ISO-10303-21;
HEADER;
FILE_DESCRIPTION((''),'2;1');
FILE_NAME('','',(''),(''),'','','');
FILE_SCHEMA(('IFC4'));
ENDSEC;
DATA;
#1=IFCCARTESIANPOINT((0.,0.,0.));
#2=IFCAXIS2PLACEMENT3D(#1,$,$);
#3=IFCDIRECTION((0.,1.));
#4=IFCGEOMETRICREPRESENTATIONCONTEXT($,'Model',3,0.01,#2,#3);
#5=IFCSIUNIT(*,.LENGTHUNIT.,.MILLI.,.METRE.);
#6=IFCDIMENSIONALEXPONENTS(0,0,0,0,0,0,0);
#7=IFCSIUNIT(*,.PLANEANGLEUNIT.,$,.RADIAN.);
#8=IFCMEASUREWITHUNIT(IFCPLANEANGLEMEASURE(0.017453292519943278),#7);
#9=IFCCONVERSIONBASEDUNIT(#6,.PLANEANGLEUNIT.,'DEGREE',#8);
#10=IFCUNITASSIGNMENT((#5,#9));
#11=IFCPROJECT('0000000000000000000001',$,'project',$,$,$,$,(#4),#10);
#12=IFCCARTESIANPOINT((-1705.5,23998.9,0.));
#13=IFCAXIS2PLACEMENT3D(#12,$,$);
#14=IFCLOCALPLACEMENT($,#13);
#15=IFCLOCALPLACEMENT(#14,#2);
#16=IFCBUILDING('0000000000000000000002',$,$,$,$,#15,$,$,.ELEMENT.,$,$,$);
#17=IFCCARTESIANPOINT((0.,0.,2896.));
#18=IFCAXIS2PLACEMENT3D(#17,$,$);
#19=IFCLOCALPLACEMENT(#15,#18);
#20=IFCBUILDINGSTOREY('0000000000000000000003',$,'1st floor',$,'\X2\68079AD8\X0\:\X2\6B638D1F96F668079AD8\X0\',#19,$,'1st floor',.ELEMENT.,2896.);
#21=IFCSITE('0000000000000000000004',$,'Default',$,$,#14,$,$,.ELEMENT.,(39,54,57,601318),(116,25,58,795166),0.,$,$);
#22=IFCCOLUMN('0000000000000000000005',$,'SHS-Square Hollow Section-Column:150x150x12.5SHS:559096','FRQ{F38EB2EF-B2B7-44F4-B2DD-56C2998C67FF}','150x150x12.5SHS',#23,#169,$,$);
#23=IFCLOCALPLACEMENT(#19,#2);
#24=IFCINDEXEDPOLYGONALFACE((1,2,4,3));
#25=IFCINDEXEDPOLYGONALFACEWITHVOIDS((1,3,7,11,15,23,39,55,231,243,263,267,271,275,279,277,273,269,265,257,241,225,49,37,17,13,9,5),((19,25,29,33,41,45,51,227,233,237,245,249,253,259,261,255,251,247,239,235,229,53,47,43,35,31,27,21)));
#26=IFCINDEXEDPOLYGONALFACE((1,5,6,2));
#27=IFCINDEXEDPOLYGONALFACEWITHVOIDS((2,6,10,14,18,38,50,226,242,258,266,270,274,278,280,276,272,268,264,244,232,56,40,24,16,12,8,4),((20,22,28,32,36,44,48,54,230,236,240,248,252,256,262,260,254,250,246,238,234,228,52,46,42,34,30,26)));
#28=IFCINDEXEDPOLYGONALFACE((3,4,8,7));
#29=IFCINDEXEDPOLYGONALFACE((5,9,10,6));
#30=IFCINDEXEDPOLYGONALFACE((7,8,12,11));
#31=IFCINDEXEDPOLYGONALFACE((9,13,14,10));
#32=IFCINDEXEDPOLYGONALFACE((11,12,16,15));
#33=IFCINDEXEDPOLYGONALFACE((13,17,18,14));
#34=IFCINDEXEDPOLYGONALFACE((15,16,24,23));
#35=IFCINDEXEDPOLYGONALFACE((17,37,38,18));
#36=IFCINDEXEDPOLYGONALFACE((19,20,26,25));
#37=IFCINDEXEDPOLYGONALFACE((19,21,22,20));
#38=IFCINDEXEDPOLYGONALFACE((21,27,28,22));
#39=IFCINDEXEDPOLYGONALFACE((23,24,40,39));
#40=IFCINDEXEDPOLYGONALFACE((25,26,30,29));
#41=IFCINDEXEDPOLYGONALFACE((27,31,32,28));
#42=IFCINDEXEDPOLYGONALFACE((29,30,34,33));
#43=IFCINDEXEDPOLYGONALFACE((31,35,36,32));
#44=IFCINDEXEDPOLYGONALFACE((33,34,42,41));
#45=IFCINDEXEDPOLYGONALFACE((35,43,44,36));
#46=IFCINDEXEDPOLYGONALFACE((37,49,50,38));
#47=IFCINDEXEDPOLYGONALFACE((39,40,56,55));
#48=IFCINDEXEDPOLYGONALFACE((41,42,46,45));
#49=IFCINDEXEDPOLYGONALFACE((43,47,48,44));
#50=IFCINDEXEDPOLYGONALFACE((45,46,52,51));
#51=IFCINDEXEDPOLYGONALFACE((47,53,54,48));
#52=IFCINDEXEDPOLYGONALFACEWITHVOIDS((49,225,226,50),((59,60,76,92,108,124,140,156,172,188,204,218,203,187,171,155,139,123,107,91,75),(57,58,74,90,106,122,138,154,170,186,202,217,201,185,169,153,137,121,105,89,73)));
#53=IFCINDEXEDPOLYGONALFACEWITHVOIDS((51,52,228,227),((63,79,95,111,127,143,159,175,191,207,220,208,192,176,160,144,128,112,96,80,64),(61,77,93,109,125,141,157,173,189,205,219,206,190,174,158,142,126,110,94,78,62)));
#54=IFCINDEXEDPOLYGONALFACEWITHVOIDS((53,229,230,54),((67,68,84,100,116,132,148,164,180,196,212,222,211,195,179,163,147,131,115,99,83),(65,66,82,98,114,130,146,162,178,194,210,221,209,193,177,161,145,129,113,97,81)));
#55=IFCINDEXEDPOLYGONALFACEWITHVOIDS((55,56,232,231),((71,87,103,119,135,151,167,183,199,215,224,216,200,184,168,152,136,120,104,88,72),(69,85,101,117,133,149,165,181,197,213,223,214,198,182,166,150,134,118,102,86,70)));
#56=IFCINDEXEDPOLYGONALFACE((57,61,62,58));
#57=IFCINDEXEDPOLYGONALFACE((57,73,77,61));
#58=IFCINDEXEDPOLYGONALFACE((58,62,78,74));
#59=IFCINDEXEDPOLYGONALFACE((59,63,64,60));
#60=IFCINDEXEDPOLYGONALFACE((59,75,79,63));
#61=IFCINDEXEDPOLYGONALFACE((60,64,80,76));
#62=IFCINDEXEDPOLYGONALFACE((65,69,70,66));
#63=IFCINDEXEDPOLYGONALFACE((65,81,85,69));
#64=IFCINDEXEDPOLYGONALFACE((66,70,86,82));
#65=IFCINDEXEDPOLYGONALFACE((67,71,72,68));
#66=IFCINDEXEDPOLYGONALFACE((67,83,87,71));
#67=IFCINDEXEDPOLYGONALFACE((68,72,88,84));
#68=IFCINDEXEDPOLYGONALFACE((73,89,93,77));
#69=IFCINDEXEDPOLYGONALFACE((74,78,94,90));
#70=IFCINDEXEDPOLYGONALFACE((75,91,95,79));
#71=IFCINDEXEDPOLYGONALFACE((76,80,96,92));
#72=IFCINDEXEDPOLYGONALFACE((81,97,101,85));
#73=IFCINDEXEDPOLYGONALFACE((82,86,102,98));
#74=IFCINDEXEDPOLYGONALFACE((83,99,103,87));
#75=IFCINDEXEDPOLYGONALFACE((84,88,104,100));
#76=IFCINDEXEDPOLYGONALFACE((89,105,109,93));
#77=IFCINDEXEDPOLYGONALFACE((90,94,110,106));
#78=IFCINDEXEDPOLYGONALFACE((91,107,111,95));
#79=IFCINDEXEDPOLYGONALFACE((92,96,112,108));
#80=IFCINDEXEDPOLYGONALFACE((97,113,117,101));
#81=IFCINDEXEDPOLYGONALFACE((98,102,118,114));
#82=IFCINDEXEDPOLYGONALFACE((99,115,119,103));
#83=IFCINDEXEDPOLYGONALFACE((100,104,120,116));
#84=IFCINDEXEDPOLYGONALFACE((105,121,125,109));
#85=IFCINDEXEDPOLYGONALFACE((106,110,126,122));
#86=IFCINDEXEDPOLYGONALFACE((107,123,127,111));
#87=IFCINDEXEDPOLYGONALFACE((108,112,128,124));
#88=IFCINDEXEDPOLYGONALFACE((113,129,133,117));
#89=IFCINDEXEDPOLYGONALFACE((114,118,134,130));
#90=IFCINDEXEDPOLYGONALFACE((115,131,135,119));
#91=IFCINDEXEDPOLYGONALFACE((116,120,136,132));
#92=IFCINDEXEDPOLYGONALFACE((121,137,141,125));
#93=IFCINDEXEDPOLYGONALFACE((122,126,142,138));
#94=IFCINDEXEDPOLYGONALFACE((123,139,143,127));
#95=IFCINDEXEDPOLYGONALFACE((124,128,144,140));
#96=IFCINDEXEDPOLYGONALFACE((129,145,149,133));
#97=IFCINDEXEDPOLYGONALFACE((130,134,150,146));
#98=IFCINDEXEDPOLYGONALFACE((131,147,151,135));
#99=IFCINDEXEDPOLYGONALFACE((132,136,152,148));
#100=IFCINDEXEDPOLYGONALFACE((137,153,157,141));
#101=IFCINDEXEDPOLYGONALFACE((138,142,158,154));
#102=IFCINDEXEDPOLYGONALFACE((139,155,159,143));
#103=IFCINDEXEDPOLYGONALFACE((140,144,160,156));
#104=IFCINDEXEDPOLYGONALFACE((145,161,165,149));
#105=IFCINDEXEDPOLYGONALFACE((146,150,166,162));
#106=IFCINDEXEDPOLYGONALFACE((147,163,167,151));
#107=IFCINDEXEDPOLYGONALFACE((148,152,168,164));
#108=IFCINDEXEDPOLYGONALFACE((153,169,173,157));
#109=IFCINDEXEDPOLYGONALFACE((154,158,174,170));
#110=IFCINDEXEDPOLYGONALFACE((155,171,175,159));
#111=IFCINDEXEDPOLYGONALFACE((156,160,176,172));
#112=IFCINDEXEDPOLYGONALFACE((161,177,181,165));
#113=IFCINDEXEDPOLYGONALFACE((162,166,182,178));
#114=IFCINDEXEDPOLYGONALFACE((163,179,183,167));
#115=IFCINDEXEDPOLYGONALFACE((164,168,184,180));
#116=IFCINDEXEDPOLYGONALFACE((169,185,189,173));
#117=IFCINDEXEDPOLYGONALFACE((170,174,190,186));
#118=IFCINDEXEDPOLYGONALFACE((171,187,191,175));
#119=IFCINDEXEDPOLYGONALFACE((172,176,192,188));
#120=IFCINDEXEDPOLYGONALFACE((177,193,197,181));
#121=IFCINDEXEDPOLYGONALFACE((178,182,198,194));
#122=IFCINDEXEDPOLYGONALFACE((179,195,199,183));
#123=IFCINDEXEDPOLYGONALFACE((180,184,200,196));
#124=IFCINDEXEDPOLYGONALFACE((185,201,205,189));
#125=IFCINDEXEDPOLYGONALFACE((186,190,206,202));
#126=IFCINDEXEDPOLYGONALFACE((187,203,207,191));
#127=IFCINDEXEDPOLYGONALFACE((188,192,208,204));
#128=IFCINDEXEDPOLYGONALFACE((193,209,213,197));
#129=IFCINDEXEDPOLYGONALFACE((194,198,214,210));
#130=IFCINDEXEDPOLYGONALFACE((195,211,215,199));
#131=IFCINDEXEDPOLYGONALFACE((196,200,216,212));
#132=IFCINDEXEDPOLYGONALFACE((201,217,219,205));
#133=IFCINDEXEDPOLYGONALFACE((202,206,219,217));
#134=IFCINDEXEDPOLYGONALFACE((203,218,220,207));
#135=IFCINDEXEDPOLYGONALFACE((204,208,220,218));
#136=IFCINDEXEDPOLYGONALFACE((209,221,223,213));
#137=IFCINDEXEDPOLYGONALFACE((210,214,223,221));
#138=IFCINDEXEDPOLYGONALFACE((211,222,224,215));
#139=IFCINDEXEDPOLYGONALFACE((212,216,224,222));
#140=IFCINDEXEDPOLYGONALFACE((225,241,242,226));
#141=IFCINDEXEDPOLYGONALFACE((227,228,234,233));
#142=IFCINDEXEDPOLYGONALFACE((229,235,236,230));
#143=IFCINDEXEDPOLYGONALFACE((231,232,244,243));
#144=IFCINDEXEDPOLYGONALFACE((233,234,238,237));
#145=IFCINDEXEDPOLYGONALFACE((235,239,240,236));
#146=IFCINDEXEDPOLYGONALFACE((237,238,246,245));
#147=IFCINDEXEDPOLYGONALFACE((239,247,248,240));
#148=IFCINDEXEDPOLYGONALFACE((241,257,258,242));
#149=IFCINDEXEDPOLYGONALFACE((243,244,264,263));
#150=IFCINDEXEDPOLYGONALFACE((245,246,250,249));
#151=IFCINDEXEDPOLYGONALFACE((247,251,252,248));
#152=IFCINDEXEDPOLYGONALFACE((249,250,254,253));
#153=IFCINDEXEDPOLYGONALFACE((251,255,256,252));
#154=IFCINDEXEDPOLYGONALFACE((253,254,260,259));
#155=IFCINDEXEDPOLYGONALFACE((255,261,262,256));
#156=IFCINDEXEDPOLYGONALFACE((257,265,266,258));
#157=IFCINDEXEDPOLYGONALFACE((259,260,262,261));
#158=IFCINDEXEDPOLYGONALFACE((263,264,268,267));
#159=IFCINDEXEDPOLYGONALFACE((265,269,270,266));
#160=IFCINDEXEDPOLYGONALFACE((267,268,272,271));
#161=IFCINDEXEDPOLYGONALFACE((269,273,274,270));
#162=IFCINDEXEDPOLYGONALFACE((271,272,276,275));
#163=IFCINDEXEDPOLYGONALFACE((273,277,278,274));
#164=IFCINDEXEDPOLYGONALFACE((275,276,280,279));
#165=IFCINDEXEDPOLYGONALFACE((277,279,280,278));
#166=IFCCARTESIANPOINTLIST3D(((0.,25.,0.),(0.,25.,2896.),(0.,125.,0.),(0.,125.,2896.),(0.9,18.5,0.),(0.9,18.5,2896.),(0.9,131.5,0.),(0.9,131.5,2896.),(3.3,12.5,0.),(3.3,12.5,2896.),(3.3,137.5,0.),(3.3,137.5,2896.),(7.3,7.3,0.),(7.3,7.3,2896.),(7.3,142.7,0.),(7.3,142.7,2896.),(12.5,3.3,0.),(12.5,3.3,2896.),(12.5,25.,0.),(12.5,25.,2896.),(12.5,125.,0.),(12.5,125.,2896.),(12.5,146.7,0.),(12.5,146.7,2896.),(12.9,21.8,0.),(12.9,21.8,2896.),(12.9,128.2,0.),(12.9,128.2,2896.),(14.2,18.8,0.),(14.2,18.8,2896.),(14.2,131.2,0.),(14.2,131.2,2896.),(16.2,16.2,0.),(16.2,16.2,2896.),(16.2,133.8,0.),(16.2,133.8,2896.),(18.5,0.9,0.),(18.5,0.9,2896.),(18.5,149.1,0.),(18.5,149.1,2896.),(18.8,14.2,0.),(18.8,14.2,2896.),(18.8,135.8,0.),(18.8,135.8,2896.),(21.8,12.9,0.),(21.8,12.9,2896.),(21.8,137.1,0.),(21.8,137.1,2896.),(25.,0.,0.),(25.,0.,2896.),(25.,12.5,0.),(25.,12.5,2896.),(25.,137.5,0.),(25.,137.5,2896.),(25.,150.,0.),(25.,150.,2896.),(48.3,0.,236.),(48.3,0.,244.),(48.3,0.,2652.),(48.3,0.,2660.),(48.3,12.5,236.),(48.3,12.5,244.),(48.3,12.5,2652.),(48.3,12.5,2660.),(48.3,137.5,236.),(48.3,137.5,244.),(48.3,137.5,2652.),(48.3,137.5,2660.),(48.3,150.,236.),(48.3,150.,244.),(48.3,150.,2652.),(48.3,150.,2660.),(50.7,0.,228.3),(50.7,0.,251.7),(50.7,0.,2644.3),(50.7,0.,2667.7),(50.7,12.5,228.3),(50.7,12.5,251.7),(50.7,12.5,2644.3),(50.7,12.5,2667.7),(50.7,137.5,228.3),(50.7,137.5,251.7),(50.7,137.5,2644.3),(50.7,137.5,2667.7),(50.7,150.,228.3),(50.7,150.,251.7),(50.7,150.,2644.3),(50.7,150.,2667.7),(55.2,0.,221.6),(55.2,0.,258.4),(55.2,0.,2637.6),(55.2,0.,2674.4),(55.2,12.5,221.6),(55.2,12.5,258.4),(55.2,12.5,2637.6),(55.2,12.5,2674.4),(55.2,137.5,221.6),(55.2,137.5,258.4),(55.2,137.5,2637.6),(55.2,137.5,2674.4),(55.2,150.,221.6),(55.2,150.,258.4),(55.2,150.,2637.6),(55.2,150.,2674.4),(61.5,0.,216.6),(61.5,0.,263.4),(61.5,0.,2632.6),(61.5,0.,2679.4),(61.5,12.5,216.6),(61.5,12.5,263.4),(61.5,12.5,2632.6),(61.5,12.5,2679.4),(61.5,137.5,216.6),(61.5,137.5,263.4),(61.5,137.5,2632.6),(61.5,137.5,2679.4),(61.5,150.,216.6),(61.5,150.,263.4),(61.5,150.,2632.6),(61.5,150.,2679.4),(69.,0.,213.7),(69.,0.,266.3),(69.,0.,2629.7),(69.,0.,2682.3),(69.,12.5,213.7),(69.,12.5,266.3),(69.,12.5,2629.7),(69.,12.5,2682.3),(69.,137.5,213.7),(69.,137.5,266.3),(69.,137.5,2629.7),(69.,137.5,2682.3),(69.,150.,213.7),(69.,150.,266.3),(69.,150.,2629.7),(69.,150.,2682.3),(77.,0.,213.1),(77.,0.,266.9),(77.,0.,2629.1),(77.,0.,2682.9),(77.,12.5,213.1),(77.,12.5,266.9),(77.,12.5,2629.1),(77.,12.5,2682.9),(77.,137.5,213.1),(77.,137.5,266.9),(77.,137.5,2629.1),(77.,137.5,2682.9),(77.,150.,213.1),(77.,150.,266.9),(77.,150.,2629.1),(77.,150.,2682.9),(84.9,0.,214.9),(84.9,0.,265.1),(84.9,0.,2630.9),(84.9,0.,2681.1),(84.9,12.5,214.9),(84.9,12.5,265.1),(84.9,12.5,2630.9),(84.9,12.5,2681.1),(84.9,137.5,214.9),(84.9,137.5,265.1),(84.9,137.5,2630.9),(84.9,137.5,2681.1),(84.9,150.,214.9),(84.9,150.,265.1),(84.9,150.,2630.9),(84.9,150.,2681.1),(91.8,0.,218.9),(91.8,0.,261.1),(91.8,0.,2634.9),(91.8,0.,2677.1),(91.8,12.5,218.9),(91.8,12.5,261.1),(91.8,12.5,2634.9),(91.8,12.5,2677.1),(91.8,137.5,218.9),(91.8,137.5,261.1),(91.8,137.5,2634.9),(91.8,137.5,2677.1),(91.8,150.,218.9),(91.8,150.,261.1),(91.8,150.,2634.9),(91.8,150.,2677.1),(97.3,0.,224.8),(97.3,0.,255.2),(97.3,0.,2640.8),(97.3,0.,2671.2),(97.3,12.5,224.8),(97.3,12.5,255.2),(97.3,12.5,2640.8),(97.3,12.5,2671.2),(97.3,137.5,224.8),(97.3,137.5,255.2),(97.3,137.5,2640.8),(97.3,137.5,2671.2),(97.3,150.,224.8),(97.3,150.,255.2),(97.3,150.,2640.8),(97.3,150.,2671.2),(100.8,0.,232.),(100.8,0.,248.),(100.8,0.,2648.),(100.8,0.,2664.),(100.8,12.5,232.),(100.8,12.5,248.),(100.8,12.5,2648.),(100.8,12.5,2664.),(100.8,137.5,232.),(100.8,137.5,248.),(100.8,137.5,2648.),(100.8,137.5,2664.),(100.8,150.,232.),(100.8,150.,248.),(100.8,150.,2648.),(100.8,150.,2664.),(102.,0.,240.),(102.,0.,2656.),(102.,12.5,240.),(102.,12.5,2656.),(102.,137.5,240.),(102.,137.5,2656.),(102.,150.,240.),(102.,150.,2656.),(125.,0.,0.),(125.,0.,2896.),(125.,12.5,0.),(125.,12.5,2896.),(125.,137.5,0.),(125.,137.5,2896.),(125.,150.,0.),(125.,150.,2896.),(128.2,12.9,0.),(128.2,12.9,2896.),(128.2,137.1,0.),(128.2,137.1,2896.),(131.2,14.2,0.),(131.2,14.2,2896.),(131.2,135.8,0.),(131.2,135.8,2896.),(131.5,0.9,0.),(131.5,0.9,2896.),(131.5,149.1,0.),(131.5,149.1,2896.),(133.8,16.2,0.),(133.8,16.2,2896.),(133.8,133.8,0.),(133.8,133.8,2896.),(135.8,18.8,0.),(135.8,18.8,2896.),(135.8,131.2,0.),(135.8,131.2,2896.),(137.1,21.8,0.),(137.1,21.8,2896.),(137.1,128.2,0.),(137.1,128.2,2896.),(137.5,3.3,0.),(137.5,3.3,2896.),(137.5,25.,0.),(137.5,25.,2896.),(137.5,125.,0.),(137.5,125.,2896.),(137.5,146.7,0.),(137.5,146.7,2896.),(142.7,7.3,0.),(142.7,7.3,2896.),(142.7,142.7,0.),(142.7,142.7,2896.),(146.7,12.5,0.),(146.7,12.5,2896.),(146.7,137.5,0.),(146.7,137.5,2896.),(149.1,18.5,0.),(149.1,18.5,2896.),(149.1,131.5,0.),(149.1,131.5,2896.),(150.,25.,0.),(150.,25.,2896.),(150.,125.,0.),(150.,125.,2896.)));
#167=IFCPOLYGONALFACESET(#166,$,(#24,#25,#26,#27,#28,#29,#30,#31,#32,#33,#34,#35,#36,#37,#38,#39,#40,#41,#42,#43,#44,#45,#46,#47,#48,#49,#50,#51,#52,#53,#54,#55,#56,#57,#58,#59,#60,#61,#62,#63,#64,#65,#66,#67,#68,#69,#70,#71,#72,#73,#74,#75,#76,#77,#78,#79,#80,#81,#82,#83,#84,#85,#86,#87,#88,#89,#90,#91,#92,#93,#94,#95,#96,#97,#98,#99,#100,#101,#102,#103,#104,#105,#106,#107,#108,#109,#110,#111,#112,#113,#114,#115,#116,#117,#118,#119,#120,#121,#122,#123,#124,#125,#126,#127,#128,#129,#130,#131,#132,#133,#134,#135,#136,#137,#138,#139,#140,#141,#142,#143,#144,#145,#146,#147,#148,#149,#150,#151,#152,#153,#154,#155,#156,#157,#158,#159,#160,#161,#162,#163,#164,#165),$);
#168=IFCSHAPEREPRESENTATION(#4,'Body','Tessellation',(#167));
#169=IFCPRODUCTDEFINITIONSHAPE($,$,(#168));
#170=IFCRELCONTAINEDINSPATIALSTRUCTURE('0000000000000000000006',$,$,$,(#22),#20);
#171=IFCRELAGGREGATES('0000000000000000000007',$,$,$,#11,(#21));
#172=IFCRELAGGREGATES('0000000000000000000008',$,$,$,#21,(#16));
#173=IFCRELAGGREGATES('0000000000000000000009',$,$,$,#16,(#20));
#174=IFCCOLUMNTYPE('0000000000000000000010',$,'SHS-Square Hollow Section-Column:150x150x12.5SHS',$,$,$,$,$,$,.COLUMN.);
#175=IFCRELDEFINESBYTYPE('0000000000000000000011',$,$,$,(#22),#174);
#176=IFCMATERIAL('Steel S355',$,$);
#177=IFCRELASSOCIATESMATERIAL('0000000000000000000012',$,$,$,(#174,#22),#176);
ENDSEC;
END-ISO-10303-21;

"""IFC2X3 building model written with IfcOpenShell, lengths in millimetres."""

from ifc_helpers import new_model, entity, si_unit, converted_unit, direction, frame, frame_2d, origin, origin_2d, place, context, project, spatial, circle_curve, hollow_rectangle, outline, extrude, material, type_object, element, save


model = new_model("IFC2X3")

# Units and contexts
model_context = context("Model", 3, precision=0.01, world=origin(), true_north=direction((0.0, 1.0)))
ifc_project = project(units=[si_unit("LENGTHUNIT", "METRE", prefix="MILLI"), converted_unit("PLANEANGLEUNIT", "DEGREE", entity("IfcPlaneAngleMeasure", 0.017453292519943278), si_unit("PLANEANGLEUNIT", "RADIAN"), dimensions=[0, 0, 0, 0, 0, 0, 0])], contexts=[model_context])

# Site, building, storey
site_placement = place(None, frame((-1705.5, 23998.9, 0.0)))
site = spatial("IfcSite", under=ifc_project, at=site_placement, Name="Default", CompositionType="ELEMENT", RefLatitude=(39, 54, 57, 601318), RefLongitude=(116, 25, 58, 795166), RefElevation=0.0)
building_placement = place(site_placement, origin())
building = spatial("IfcBuilding", under=site, at=building_placement, CompositionType="ELEMENT")
storey_placement = place(building_placement, frame((0.0, 0.0, 2896.0)))
storey = spatial("IfcBuildingStorey", under=building, at=storey_placement, Name="1st floor", ObjectType="标高:正负零标高", LongName="1st floor", CompositionType="ELEMENT", Elevation=2896.0)

# Shared definitions
ifc_material_1 = material(Name="Steel S355")

# Column, openings
column_type_1 = type_object("IfcColumnType", Name="SHS-Square Hollow Section-Column:150x150x12.5SHS", PredefinedType="COLUMN", material=ifc_material_1)
column_1_placement = place(storey_placement, frame((75.0, 75.0, 2896.0), z_axis=(0.0, 0.0, 1.0), x_axis=(0.0, -1.0, 0.0)))
column_1 = element("IfcColumn", 1, at=column_1_placement, inside=storey, type_object=column_type_1, material=ifc_material_1, Name="SHS-Square Hollow Section-Column:150x150x12.5SHS:559096", Description="FRQ{F38EB2EF-B2B7-44F4-B2DD-56C2998C67FF}", ObjectType="150x150x12.5SHS", context=model_context, shape_type="SweptSolid", body=[
    extrude(hollow_rectangle(XDim=150.0, YDim=150.0, WallThickness=12.5, InnerFilletRadius=12.5, OuterFilletRadius=25.0, at=origin_2d()), origin(), (0.0, 0.0, -1.0), 2896.0),
])
opening_1_placement = place(column_1_placement, frame((-175.1, 0.0, -2896.0), z_axis=(1.0, 0.0, 0.0), x_axis=(0.0, 1.0, 0.0)))
element("IfcOpeningElement", 2, at=opening_1_placement, cuts=column_1, ObjectType="Opening", context=model_context, shape_type="SweptSolid", body=[
    extrude(outline(circle_curve(frame_2d((0.0, 240.0), x_axis=(1.0, 0.0)), 27.0)), origin(), (0.0, 0.0, 1.0), 350.2),
])
opening_2_placement = place(column_1_placement, frame((-175.1, 0.0, 0.0), z_axis=(1.0, 0.0, 0.0), x_axis=(0.0, 1.0, 0.0)))
element("IfcOpeningElement", 3, at=opening_2_placement, cuts=column_1, ObjectType="Opening", context=model_context, shape_type="SweptSolid", body=[
    extrude(outline(circle_curve(frame_2d((0.0, -240.0), x_axis=(1.0, 0.0)), 27.0)), origin(), (0.0, 0.0, 1.0), 350.2),
])

save(model, "model.ifc")
